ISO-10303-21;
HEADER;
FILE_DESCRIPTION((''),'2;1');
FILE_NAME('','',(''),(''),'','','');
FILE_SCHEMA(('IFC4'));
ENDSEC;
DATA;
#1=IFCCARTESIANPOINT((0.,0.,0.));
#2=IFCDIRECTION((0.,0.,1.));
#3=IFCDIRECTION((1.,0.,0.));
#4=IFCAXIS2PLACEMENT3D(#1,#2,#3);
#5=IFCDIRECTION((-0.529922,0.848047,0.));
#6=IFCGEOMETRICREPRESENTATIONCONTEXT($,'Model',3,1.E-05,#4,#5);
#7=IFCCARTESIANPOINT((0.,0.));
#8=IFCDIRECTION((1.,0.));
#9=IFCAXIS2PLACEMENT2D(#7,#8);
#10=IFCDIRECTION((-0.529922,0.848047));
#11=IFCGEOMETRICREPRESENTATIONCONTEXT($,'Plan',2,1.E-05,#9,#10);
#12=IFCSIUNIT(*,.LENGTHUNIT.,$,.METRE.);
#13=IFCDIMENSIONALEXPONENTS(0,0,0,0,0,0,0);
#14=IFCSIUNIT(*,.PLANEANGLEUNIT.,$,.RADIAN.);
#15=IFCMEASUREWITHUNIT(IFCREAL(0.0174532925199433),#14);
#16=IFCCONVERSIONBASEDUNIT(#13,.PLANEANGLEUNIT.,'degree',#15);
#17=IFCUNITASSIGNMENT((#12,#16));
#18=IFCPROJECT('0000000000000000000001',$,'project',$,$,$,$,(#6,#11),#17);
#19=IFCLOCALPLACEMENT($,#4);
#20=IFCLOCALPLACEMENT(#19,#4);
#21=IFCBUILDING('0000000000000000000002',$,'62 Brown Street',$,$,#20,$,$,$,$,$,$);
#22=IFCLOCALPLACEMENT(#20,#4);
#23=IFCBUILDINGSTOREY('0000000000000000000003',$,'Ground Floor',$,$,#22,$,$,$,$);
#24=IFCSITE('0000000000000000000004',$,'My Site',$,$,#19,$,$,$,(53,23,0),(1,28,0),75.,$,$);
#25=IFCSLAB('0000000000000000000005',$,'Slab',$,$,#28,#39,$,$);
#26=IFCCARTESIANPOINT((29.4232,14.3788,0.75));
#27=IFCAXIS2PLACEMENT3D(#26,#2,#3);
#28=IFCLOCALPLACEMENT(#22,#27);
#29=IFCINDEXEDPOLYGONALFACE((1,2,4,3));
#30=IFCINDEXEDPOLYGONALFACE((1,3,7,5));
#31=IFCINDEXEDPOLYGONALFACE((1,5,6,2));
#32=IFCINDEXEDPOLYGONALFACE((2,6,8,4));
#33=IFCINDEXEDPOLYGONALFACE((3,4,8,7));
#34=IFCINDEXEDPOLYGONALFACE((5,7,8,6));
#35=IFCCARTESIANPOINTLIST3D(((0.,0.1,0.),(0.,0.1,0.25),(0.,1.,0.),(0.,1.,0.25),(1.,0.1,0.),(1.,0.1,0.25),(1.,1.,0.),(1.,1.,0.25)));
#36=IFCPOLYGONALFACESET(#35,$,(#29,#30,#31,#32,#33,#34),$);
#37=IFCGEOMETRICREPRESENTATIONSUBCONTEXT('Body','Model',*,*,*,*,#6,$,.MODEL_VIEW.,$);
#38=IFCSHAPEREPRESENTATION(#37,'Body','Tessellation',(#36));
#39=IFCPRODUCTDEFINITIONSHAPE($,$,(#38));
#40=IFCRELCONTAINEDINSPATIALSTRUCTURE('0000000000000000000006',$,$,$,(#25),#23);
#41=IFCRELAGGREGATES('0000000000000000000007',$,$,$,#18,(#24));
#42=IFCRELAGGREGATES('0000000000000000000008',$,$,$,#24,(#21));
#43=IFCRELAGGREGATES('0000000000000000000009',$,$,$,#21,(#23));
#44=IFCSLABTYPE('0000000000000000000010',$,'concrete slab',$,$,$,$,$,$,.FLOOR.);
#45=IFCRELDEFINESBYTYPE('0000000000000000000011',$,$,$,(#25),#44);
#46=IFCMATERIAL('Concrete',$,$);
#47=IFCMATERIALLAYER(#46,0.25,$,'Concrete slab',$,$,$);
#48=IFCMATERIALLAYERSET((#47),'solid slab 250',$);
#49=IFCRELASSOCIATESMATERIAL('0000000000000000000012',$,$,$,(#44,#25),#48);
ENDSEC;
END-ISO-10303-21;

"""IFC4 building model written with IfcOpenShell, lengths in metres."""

from ifc_helpers import new_model, entity, si_unit, converted_unit, direction, frame, origin_with_axes, origin_2d_with_axis, place, context, subcontext, project, spatial, line, indexed_curve, outline, extrude, material, layer, layer_set, layer_usage, type_object, element, save


model = new_model("IFC4")

# Units and contexts
model_context = context("Model", 3, precision=1e-05, world=origin_with_axes(), true_north=direction((-0.529922, 0.848047, 0.0)))
plan_context = context("Plan", 2, precision=1e-05, world=origin_2d_with_axis(), true_north=direction((-0.529922, 0.848047)))
body_context_1 = subcontext(model_context, "Body", "Model", "MODEL_VIEW")
ifc_project = project(units=[si_unit("LENGTHUNIT", "METRE"), converted_unit("PLANEANGLEUNIT", "degree", entity("IfcReal", 0.0174532925199433), si_unit("PLANEANGLEUNIT", "RADIAN"), dimensions=[0, 0, 0, 0, 0, 0, 0])], contexts=[model_context, plan_context])

# Site, building, storey
site_placement = place(None, origin_with_axes())
site = spatial("IfcSite", under=ifc_project, at=site_placement, Name="My Site", RefLatitude=(53, 23, 0), RefLongitude=(1, 28, 0), RefElevation=75.0)
building_placement = place(site_placement, origin_with_axes())
building = spatial("IfcBuilding", under=site, at=building_placement, Name="62 Brown Street")
storey_placement = place(building_placement, origin_with_axes())
storey = spatial("IfcBuildingStorey", under=building, at=storey_placement, Name="Ground Floor")

# Shared definitions
ifc_material_1 = material(Name="Concrete")

# Slab
ifc_layer_1 = layer(ifc_material_1, 0.25, Name="Concrete slab")
ifc_layer_set_1 = layer_set([ifc_layer_1], Name="solid slab 250")
ifc_layer_usage_1 = layer_usage(ifc_layer_set_1, "AXIS3", "POSITIVE", 0.0)
slab_type = type_object("IfcSlabType", Name="concrete slab", PredefinedType="FLOOR", material=ifc_layer_set_1)
slab_1_placement = place(storey_placement, frame((29.4232, 14.3788, 0.75), z_axis=(0.0, 0.0, 1.0), x_axis=(1.0, 0.0, 0.0)))
element("IfcSlab", 1, at=slab_1_placement, inside=storey, type_object=slab_type, material=ifc_layer_usage_1, Name="Slab", context=body_context_1, shape_type="SweptSolid", body=[
    extrude(outline(indexed_curve([(1.0, 1.0), (1.0, 0.1), (0.0, 0.1), (0.0, 1.0)], segments=[line(3, 2), line(2, 1), line(1, 4), line(4, 3)], self_intersect=False)), None, (0.0, 0.0, 1.0), 0.25),
])

save(model, "model.ifc")
